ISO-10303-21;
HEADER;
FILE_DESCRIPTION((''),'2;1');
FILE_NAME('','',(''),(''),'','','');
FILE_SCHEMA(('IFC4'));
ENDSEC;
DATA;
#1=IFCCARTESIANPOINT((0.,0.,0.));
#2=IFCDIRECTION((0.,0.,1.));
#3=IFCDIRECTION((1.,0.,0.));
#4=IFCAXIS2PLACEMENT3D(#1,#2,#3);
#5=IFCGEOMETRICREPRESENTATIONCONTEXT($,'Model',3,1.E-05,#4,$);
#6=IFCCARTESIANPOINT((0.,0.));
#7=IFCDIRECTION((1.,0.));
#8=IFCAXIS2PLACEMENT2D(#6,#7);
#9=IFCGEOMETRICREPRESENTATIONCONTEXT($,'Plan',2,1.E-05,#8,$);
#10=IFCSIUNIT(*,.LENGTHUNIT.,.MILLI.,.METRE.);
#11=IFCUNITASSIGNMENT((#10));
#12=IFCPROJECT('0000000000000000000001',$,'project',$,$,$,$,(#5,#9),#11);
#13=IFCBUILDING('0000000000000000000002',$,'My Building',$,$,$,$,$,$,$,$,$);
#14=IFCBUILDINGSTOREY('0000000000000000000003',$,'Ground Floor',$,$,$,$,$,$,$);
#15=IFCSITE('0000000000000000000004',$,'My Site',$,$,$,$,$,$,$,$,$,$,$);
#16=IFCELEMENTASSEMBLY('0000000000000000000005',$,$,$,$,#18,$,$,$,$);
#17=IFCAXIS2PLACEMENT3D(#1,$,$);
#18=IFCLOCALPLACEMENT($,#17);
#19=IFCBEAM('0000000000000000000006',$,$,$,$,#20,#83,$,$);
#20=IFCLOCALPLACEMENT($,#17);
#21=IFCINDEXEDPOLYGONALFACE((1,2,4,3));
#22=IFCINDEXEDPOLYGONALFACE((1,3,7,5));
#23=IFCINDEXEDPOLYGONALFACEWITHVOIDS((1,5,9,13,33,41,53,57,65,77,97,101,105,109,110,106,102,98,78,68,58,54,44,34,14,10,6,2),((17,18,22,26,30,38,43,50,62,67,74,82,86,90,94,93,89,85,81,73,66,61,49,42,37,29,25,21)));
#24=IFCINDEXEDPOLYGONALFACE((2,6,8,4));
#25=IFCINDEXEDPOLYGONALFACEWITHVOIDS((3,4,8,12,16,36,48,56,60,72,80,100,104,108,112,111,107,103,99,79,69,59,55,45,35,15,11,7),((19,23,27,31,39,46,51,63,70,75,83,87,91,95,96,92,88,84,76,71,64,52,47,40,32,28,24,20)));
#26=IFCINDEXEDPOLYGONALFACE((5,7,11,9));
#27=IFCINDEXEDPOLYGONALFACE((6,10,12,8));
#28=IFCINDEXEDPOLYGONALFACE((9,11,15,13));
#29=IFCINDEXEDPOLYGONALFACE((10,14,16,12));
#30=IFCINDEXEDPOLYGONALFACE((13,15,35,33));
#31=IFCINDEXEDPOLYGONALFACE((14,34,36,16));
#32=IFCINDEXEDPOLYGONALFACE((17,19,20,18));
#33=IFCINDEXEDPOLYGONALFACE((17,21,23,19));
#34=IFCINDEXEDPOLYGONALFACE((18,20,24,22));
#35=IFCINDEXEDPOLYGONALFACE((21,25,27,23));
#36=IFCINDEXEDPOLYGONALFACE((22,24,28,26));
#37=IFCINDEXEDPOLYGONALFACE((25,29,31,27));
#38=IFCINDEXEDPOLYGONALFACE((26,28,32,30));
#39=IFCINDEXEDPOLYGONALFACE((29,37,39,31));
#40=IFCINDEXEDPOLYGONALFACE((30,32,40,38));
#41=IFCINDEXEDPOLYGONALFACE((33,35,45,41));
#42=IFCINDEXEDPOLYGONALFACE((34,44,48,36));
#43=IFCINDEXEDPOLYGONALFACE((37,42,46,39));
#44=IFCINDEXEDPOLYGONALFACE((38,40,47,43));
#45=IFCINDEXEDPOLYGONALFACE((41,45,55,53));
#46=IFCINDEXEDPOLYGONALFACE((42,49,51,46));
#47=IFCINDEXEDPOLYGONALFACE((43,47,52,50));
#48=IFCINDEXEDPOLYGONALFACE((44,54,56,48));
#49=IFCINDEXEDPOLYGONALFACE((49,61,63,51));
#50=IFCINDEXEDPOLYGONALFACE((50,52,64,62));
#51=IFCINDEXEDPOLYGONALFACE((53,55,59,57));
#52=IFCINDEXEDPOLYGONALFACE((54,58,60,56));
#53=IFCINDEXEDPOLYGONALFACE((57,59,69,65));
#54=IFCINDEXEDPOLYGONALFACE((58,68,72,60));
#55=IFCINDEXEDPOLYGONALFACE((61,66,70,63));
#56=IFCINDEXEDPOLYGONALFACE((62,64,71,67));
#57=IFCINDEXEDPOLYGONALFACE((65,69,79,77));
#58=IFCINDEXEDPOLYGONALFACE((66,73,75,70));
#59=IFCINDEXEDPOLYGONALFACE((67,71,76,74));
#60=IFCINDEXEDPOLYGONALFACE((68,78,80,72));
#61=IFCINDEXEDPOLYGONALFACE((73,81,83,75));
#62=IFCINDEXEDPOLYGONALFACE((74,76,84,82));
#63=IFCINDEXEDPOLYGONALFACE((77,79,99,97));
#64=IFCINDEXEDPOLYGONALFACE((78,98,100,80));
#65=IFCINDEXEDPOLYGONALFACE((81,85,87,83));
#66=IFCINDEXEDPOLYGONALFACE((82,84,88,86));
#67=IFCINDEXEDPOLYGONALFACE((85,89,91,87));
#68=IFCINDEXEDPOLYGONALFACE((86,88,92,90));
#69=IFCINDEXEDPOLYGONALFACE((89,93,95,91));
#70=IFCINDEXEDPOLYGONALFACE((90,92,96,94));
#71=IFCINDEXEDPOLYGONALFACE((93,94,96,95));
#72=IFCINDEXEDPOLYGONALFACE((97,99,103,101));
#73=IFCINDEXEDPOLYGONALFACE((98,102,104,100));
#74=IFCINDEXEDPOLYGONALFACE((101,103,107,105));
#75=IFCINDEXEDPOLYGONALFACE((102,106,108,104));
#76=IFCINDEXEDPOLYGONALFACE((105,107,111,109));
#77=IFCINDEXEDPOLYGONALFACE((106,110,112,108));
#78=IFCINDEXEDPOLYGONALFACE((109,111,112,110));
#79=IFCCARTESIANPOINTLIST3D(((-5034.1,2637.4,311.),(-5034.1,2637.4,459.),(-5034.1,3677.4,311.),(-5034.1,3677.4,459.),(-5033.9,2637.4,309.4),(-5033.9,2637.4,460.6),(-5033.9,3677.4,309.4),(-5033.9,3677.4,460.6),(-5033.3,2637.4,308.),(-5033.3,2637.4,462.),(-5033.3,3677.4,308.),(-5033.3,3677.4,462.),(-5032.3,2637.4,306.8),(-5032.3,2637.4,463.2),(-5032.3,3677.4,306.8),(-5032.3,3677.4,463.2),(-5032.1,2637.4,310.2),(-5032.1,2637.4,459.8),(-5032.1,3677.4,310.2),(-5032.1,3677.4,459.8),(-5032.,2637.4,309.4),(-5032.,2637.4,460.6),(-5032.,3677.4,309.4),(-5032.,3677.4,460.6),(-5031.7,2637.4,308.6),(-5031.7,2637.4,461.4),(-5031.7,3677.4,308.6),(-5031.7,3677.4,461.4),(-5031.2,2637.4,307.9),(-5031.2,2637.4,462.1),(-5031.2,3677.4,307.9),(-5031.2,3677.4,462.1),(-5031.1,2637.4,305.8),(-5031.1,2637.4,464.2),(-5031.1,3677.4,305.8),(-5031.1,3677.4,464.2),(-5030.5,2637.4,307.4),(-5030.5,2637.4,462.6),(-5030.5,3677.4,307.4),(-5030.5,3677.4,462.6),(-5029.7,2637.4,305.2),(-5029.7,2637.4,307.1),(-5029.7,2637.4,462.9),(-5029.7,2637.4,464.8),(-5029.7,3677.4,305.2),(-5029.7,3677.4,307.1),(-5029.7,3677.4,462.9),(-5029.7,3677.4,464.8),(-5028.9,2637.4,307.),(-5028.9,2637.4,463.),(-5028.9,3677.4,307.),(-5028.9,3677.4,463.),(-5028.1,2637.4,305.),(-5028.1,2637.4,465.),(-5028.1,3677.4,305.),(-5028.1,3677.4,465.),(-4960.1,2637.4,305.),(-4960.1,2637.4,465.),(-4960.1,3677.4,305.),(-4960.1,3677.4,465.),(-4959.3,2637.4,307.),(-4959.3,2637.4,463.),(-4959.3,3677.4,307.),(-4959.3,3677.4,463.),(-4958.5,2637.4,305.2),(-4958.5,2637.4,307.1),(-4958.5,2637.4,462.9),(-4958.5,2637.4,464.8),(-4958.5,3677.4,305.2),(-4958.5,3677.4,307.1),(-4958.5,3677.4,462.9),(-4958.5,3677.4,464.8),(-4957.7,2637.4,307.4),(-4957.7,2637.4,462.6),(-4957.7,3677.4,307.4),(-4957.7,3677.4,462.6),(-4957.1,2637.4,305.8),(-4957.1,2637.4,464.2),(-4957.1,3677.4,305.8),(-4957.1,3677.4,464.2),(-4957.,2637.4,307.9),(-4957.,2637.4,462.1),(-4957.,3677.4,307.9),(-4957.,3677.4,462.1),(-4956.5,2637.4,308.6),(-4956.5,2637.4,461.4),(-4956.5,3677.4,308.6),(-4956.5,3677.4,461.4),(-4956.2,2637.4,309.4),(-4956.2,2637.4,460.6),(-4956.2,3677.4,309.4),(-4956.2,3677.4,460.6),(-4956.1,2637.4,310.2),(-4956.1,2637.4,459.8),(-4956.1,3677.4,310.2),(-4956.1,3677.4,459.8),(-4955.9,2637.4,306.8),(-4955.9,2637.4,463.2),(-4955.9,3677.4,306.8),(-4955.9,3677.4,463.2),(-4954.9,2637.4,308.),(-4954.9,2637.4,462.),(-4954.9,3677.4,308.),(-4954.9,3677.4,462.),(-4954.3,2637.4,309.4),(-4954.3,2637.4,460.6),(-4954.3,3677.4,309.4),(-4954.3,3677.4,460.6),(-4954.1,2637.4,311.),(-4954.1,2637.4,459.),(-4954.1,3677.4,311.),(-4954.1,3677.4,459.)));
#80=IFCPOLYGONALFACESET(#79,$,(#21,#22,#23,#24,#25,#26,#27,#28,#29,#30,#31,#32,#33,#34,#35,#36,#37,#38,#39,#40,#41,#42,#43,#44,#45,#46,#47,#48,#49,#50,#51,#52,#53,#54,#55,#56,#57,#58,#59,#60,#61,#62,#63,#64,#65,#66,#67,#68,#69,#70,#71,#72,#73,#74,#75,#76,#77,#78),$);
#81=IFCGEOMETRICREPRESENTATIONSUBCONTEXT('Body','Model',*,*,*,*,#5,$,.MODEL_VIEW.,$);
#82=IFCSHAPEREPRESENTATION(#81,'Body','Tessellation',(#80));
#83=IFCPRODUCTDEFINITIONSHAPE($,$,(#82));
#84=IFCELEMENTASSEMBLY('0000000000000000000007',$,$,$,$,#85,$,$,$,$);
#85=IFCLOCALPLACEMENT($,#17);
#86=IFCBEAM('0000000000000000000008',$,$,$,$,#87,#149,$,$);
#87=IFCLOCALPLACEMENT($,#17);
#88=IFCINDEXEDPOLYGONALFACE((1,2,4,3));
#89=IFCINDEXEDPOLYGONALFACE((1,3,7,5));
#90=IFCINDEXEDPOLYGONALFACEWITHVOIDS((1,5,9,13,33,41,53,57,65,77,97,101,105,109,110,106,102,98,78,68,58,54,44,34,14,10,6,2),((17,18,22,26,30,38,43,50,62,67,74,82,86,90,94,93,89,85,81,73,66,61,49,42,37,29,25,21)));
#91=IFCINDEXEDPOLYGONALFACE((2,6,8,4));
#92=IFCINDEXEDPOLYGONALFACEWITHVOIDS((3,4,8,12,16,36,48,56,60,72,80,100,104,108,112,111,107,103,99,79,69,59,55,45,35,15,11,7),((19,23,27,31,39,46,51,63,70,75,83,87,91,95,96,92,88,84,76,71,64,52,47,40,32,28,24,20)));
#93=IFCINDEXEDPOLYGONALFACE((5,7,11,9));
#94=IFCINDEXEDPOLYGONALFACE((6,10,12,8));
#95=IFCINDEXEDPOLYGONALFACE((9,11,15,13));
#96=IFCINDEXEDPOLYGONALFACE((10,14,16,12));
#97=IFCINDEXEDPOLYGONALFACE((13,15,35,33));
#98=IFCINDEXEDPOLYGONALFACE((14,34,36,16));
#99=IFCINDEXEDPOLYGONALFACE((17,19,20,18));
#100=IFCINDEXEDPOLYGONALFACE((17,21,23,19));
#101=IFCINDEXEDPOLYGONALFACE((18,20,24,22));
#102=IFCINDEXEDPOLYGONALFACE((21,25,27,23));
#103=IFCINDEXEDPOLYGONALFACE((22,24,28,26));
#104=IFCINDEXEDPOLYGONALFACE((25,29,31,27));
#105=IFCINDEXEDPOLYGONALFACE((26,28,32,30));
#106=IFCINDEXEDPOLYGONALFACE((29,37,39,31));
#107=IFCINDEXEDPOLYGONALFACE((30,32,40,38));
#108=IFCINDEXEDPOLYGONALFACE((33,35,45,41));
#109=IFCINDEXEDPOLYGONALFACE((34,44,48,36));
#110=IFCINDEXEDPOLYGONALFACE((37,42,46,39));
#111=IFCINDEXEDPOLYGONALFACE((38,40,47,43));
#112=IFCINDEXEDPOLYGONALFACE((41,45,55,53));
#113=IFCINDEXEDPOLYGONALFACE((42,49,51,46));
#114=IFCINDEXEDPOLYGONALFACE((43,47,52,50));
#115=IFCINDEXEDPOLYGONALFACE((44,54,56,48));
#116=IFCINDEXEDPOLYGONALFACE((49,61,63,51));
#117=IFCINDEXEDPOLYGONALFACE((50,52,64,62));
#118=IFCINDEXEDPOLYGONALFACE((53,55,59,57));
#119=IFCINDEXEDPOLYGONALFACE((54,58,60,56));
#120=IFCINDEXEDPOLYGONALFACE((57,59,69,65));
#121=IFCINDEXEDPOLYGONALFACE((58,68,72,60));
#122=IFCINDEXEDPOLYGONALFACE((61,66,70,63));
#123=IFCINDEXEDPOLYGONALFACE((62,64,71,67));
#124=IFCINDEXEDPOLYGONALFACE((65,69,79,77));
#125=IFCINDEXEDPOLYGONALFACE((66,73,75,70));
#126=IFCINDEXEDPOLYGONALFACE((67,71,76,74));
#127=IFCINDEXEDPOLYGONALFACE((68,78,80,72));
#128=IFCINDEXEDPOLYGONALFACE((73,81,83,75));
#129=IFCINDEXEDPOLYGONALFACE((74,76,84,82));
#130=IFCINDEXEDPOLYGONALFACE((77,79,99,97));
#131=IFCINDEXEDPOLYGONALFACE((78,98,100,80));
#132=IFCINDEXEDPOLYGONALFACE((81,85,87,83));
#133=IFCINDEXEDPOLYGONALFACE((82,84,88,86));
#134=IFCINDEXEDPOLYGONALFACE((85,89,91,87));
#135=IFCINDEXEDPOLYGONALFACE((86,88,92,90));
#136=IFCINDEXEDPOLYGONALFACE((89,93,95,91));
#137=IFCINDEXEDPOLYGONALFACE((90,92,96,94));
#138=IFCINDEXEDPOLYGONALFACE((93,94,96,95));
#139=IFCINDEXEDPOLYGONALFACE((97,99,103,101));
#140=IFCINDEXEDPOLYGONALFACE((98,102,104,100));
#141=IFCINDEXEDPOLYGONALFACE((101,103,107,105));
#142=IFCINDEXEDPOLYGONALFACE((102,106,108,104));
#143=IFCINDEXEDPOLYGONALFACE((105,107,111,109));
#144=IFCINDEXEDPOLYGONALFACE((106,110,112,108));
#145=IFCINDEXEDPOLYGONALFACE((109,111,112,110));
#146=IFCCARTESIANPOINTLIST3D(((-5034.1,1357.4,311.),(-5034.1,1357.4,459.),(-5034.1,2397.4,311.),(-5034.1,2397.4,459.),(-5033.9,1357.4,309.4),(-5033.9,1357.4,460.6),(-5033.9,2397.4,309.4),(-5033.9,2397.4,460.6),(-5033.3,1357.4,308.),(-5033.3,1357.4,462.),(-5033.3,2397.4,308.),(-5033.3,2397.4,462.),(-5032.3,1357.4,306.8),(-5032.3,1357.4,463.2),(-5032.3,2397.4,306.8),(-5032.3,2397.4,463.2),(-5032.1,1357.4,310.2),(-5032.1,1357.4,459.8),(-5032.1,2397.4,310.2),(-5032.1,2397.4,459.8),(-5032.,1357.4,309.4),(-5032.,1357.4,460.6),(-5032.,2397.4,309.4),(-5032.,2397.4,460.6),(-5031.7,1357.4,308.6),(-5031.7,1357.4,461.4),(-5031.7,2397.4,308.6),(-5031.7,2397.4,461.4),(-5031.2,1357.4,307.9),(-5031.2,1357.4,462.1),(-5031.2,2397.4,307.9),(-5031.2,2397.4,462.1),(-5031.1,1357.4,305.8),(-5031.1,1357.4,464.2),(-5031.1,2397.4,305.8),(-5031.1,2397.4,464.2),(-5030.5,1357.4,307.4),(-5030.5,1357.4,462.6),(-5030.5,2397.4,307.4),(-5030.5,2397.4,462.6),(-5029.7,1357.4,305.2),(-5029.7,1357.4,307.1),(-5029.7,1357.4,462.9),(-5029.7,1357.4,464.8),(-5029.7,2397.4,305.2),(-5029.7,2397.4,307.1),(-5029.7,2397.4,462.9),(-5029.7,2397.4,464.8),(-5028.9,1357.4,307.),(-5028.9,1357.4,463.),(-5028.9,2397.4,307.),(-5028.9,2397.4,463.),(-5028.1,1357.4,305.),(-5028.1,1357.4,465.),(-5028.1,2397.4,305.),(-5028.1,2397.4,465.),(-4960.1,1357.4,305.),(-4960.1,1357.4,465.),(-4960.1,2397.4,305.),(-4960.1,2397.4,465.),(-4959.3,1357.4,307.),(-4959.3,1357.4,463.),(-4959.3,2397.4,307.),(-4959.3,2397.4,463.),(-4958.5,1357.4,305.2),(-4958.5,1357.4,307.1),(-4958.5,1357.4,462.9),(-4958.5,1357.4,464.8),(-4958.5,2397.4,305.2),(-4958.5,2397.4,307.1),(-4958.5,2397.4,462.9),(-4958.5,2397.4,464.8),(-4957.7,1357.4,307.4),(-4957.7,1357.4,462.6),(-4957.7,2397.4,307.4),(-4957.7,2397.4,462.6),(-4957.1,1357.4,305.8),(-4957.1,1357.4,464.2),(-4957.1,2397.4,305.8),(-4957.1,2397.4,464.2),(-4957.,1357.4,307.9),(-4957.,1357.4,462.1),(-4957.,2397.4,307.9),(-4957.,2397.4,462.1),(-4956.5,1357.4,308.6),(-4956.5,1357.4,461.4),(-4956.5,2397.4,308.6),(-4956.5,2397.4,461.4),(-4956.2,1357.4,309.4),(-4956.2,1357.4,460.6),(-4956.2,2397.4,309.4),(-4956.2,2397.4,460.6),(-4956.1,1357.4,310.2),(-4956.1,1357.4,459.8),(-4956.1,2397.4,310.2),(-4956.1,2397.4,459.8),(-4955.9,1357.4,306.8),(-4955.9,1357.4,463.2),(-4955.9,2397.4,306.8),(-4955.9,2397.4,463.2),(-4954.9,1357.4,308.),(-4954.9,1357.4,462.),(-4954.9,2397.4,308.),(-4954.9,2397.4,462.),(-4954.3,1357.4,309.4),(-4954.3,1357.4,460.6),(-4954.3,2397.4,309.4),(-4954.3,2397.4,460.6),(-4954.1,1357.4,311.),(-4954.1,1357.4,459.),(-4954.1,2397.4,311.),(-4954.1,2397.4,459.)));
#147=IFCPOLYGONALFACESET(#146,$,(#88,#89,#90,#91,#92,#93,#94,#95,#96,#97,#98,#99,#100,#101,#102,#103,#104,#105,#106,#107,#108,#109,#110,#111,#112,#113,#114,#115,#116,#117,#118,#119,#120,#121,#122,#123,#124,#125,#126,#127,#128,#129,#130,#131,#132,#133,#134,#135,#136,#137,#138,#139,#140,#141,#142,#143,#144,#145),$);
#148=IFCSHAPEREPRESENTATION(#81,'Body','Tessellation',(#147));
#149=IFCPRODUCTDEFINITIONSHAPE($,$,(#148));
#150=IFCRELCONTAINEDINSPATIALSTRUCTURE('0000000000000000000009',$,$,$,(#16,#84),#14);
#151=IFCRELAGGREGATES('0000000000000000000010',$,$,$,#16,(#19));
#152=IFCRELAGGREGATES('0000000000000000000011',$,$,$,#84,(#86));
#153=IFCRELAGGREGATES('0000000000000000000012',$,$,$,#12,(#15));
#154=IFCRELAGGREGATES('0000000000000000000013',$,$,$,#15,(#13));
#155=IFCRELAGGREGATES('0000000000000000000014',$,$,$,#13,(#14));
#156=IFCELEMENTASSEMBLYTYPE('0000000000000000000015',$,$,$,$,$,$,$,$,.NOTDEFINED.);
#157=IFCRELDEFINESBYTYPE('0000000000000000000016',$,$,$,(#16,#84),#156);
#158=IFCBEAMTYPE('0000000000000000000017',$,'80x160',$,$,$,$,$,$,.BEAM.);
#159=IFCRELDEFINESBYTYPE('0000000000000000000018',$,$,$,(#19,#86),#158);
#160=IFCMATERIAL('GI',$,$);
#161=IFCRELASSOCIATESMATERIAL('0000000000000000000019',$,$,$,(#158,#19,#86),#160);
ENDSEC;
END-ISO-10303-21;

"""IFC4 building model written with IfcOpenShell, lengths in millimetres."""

from ifc_helpers import new_model, si_unit, frame, origin_with_axes, origin_2d_with_axis, place, context, subcontext, project, spatial, hollow_rectangle, extrude, material, material_profile, profile_set, profile_usage, type_object, element, aggregate, save


model = new_model("IFC4")

# Units and contexts
model_context = context("Model", 3, precision=1e-05, world=origin_with_axes())
plan_context = context("Plan", 2, precision=1e-05, world=origin_2d_with_axis())
body_context = subcontext(model_context, "Body", "Model", "MODEL_VIEW")
ifc_project = project(units=[si_unit("LENGTHUNIT", "METRE", prefix="MILLI")], contexts=[model_context, plan_context])

# Site, building, storey
site = spatial("IfcSite", under=ifc_project, Name="My Site")
building = spatial("IfcBuilding", under=site, Name="My Building")
storey = spatial("IfcBuildingStorey", under=building, Name="Ground Floor")

# Shared definitions
ifc_material = material(Name="GI")

# Element assemblies, beams
element_assembly_type_1 = type_object("IfcElementAssemblyType", PredefinedType="NOTDEFINED")
ifc_material_profile_1 = material_profile(ifc_material, hollow_rectangle(XDim=80.0, YDim=160.0, WallThickness=2.0, InnerFilletRadius=3.2, OuterFilletRadius=6.0))
ifc_profile_set_1 = profile_set([ifc_material_profile_1], Name="80x160 GI Rectangular Hollow")
beam_type = type_object("IfcBeamType", Name="80x160", PredefinedType="BEAM", material=ifc_profile_set_1)
assembly_1_placement = place(None, frame((-4994.1, 2557.4, 385.0), z_axis=(0.0, 1.0, 0.0), x_axis=(1.0, 0.0, 0.0)))
assembly_1 = element("IfcElementAssembly", 1, at=assembly_1_placement, inside=storey, type_object=element_assembly_type_1)
ifc_profile_usage_1 = profile_usage(ifc_profile_set_1)
beam_1_placement = place(assembly_1_placement, frame((0.0, 0.0, 80.0), z_axis=(0.0, 0.0, 1.0), x_axis=(1.0, 0.0, 0.0)))
beam_1 = element("IfcBeam", 2, at=beam_1_placement, type_object=beam_type, material=ifc_profile_usage_1, context=body_context, shape_type="SweptSolid", body=[
    extrude(hollow_rectangle(XDim=80.0, YDim=160.0, WallThickness=2.0, InnerFilletRadius=3.2, OuterFilletRadius=6.0), origin_with_axes(), (0.0, 0.0, 1.0), 1040.0),
])
aggregate(assembly_1, [beam_1])
assembly_2_placement = place(None, frame((-4994.1, 1277.4, 385.0), z_axis=(0.0, 1.0, 0.0), x_axis=(1.0, 0.0, 0.0)))
assembly_2 = element("IfcElementAssembly", 3, at=assembly_2_placement, inside=storey, type_object=element_assembly_type_1)
ifc_profile_usage_2 = profile_usage(ifc_profile_set_1)
beam_2_placement = place(assembly_2_placement, frame((0.0, 0.0, 80.0), z_axis=(0.0, 0.0, 1.0), x_axis=(1.0, 0.0, 0.0)))
beam_2 = element("IfcBeam", 4, at=beam_2_placement, type_object=beam_type, material=ifc_profile_usage_2, context=body_context, shape_type="SweptSolid", body=[
    extrude(hollow_rectangle(XDim=80.0, YDim=160.0, WallThickness=2.0, InnerFilletRadius=3.2, OuterFilletRadius=6.0), origin_with_axes(), (0.0, 0.0, 1.0), 1040.0),
])
aggregate(assembly_2, [beam_2])

save(model, "model.ifc")
